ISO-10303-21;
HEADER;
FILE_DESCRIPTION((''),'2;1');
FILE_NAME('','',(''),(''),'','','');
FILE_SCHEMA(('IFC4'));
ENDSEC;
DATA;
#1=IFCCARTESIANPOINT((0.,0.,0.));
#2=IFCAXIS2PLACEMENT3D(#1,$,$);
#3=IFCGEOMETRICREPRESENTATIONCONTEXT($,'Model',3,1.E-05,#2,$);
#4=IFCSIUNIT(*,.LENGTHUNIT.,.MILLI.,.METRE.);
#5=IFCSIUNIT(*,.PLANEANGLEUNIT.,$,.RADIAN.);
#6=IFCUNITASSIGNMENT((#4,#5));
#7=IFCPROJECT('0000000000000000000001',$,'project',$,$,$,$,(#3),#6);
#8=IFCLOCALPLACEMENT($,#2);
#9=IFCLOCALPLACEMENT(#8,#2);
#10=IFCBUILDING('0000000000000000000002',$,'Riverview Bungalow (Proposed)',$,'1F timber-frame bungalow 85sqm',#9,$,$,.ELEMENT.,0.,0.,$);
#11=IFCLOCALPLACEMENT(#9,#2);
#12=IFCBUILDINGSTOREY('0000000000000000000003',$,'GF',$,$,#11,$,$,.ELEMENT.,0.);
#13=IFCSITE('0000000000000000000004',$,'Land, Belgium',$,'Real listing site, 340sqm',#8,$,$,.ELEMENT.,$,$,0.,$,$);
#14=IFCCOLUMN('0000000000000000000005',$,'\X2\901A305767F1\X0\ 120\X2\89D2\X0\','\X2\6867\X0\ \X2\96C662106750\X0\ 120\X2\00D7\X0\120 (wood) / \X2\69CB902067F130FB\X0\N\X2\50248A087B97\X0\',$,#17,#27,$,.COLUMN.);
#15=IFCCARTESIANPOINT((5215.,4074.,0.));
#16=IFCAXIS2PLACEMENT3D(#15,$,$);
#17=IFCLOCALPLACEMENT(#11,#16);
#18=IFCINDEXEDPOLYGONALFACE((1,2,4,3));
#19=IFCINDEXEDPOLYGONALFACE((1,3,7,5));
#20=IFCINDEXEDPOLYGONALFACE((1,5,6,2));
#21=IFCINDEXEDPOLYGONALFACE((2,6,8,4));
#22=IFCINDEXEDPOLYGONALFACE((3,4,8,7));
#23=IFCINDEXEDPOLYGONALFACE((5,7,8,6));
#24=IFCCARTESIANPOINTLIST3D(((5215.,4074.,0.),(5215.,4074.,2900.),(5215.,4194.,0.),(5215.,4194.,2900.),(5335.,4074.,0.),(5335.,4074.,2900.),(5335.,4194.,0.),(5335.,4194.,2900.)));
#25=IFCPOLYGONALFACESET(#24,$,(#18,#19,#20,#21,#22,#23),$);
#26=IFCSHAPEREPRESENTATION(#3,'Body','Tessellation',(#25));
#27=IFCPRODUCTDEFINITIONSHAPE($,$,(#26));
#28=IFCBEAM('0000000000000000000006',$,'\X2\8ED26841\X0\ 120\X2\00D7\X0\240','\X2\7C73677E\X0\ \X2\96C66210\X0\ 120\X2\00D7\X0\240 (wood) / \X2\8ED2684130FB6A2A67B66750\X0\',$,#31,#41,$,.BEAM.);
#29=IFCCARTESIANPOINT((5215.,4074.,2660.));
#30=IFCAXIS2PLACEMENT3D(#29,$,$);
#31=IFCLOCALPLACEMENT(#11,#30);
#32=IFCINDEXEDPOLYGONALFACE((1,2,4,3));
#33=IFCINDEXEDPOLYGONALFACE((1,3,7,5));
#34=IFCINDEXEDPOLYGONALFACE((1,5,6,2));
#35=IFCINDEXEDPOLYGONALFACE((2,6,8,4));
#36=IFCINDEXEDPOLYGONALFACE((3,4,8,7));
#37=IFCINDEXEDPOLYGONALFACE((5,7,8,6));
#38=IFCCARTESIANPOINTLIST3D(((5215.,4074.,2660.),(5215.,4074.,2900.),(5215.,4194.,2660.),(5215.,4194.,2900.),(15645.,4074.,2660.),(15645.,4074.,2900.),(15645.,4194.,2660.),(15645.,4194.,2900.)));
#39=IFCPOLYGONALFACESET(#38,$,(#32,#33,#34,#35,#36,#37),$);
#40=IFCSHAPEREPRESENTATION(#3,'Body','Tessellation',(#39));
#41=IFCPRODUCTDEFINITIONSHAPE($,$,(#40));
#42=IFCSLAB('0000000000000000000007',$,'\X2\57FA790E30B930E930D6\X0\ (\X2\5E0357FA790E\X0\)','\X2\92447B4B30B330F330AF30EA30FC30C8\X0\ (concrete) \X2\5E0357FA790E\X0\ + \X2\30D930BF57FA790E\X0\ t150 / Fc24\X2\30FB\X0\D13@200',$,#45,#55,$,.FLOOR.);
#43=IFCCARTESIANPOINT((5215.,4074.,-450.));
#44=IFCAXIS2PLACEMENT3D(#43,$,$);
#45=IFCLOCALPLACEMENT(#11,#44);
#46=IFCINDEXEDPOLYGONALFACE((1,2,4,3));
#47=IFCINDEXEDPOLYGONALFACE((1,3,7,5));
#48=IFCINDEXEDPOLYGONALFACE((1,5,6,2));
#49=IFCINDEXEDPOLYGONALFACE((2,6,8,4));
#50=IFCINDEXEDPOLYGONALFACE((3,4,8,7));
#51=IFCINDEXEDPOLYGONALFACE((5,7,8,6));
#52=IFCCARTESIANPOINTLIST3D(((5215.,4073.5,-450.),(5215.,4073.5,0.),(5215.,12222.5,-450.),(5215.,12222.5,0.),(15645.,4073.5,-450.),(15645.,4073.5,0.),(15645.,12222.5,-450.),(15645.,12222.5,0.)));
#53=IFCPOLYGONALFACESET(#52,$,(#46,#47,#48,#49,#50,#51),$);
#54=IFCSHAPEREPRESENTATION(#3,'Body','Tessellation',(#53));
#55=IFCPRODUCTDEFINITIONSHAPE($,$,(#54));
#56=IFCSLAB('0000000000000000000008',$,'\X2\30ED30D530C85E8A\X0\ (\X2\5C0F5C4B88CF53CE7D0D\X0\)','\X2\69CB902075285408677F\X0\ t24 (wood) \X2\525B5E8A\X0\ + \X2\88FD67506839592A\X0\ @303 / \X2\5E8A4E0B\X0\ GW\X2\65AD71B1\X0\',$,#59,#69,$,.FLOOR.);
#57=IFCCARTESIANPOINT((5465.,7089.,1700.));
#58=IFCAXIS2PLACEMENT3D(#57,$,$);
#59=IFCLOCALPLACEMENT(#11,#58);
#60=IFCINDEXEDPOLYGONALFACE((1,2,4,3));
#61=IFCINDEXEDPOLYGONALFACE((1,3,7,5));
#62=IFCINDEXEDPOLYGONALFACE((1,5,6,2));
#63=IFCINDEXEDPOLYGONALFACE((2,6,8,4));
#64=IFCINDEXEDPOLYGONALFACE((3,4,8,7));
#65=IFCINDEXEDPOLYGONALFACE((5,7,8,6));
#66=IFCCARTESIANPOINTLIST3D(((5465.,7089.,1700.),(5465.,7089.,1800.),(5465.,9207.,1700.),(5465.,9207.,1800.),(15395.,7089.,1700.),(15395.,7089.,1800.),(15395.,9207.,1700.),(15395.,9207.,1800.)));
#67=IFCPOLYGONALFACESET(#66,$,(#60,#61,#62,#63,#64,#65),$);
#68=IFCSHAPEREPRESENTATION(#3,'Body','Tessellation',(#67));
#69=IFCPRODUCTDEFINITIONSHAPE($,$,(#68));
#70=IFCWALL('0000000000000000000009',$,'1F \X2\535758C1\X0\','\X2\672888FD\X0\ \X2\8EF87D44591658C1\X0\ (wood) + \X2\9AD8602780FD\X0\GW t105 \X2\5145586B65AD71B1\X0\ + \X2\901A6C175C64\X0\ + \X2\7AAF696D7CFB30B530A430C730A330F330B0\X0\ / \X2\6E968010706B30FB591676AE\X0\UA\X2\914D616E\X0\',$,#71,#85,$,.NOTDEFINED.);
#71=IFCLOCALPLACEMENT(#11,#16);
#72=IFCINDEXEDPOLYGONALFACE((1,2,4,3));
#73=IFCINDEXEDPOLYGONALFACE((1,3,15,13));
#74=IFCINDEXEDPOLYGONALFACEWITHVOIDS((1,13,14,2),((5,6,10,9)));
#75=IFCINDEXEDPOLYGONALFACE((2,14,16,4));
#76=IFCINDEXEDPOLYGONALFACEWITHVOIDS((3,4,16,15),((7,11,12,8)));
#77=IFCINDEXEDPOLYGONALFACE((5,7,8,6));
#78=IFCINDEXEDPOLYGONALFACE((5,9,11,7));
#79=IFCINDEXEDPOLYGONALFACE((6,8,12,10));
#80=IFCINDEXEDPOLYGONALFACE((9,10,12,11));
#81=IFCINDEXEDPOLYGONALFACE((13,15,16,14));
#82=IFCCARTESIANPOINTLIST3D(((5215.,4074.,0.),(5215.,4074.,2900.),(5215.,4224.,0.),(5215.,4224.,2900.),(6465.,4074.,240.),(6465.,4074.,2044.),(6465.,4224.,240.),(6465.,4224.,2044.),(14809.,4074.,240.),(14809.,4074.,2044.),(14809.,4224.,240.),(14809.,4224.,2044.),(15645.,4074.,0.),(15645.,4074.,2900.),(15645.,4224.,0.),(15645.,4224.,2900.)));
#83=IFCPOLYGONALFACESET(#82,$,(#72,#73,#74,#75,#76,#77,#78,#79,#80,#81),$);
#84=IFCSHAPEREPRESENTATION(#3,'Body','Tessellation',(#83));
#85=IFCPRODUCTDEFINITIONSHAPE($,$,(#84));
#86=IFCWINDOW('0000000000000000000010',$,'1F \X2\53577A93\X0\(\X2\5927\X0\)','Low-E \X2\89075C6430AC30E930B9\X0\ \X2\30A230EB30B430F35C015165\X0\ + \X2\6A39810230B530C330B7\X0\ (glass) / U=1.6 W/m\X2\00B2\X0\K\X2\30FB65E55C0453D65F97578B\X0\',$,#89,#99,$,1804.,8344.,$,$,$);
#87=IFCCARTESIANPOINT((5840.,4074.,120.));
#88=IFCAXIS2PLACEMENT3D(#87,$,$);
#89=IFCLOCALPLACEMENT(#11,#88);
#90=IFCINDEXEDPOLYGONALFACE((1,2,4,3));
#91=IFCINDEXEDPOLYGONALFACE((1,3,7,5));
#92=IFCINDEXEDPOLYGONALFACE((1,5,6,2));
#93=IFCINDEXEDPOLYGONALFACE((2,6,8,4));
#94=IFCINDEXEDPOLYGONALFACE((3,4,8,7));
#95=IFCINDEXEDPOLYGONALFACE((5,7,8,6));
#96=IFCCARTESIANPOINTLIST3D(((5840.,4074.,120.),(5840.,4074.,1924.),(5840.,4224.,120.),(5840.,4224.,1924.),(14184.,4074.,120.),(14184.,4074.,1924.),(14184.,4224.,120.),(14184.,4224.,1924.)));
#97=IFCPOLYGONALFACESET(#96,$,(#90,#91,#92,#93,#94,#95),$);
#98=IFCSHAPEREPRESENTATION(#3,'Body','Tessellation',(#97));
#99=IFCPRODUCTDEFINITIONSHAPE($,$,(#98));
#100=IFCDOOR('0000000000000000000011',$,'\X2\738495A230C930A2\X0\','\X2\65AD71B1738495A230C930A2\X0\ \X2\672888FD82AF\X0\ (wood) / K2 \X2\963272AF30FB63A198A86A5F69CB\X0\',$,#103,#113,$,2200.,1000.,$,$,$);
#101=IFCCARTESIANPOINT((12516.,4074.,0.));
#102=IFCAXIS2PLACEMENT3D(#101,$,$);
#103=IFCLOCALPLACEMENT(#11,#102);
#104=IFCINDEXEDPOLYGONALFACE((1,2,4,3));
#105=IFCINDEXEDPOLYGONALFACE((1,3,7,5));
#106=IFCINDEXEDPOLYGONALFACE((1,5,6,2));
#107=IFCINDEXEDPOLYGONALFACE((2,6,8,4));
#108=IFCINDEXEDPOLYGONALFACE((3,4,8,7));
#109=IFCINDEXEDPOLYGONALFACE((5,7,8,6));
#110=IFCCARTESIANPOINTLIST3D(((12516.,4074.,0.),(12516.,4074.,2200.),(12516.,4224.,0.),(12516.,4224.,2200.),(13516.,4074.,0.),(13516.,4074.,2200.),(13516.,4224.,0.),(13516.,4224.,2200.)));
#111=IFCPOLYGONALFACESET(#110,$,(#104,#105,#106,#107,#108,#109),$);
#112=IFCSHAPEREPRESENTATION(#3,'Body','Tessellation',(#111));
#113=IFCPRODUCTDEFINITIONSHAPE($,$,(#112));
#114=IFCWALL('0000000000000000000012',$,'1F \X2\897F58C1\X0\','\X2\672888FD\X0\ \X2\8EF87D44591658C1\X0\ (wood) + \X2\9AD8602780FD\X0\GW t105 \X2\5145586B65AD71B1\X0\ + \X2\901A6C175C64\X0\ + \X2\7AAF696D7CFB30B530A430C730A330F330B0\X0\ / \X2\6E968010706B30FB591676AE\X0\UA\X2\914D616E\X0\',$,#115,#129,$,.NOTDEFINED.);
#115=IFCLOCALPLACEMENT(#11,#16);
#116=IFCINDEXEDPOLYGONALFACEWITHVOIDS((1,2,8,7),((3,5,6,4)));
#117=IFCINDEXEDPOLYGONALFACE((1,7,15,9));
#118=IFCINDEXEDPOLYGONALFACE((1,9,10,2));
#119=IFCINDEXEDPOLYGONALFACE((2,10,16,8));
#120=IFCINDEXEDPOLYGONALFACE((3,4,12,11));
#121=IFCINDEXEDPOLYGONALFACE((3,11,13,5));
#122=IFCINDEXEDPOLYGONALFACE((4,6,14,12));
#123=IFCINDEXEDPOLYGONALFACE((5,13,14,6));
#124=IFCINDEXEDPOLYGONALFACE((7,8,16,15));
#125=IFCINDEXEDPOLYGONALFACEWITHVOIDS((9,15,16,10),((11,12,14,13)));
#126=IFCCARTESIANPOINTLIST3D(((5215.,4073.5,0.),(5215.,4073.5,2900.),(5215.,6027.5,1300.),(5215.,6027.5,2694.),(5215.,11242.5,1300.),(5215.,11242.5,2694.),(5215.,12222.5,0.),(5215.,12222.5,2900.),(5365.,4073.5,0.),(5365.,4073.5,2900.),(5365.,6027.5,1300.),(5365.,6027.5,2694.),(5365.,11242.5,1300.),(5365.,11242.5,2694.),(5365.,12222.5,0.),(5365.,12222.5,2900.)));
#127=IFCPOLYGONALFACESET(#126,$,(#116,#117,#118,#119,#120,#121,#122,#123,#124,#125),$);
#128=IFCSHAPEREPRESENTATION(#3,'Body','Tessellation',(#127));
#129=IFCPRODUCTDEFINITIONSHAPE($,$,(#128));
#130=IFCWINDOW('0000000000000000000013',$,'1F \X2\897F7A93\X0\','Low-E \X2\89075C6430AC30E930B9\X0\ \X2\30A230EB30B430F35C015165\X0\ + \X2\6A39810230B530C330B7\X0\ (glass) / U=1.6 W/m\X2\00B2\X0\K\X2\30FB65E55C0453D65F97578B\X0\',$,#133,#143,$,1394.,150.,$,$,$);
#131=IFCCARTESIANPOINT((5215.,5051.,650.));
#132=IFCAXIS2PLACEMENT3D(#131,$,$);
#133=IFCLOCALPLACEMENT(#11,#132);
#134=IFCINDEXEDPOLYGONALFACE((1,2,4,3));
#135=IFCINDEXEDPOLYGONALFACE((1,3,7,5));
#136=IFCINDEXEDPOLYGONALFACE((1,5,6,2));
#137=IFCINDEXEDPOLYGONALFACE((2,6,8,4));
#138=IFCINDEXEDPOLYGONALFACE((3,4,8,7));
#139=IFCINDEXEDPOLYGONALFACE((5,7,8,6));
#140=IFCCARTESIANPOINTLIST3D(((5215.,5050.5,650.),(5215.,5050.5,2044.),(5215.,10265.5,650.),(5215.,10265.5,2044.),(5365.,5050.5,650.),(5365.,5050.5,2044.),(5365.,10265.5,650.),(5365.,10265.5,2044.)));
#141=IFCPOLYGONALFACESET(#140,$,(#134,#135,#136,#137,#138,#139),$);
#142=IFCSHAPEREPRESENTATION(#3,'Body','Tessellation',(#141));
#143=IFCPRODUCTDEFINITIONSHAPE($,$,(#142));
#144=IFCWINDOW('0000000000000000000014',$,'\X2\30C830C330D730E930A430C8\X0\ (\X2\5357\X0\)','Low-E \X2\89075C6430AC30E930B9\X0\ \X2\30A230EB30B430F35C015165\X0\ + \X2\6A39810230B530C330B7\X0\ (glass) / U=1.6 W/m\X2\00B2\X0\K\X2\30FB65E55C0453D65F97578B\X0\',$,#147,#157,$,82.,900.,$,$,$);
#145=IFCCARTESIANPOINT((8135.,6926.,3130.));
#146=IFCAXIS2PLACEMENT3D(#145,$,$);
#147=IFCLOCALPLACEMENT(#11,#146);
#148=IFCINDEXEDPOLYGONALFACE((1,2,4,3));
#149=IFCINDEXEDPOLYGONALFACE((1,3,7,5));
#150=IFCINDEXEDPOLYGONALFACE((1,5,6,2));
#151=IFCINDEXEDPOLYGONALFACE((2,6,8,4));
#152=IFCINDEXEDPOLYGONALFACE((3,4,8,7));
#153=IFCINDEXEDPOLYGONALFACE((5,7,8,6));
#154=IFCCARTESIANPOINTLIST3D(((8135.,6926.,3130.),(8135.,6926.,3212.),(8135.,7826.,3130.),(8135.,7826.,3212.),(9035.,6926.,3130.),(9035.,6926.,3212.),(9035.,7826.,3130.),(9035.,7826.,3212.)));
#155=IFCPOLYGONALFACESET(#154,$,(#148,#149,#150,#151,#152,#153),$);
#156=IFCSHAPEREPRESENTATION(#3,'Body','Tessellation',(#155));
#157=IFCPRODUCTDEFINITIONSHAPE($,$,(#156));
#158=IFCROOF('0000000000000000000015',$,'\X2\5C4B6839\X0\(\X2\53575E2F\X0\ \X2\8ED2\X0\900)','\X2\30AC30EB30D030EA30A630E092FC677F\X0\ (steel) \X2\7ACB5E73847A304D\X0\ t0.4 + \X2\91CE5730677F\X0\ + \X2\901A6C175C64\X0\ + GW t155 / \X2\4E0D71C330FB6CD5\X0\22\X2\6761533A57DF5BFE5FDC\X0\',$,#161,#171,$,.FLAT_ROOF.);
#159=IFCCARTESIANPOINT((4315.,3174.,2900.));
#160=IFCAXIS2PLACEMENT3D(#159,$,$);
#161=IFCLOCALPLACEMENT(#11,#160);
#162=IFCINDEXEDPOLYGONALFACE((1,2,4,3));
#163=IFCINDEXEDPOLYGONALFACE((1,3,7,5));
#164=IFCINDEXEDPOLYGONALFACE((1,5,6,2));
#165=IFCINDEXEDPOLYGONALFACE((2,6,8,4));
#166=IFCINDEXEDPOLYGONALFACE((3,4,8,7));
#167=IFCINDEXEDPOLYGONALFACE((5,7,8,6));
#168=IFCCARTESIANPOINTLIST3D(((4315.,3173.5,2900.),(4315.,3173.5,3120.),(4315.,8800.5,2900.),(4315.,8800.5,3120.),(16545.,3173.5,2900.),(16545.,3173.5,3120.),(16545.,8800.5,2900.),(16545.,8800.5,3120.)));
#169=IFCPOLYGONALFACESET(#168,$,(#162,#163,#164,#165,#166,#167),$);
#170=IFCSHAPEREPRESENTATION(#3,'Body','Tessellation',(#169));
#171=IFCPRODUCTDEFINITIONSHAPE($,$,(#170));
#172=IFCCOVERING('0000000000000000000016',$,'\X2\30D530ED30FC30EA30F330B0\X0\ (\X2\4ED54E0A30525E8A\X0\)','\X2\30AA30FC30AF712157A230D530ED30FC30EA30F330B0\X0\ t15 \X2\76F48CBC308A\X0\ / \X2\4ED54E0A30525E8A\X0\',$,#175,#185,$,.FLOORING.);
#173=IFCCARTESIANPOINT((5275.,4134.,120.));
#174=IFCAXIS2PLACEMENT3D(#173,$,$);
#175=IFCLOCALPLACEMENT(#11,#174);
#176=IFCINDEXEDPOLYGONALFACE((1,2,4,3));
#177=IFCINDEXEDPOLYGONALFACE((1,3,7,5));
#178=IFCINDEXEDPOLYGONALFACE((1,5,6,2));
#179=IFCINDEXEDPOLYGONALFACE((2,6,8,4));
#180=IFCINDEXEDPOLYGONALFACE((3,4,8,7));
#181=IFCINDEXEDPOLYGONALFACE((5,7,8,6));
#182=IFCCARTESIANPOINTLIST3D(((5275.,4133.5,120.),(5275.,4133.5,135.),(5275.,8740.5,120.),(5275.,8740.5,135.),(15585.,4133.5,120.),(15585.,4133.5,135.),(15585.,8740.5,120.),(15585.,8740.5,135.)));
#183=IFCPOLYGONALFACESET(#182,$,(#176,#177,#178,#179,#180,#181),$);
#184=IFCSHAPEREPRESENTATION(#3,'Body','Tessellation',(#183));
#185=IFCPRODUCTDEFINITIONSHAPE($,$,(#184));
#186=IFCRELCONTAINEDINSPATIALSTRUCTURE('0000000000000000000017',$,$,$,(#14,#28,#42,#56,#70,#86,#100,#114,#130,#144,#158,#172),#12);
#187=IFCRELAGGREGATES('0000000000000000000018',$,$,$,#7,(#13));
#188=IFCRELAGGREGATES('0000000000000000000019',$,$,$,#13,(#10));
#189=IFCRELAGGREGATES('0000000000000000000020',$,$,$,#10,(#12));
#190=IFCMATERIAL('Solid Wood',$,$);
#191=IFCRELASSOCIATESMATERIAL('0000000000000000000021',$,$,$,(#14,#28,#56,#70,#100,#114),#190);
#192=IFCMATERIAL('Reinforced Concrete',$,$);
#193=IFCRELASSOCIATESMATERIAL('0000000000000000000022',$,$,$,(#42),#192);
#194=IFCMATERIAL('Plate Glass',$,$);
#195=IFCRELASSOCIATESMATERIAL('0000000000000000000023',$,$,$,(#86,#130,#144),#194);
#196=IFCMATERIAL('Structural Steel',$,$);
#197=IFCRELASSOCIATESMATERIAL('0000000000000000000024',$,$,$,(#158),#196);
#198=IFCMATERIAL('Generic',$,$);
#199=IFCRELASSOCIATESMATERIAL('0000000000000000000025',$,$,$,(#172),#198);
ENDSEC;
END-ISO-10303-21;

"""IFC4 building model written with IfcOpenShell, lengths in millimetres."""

from ifc_helpers import new_model, si_unit, frame, frame_2d, origin, place, context, project, spatial, rectangle, extrude, material, element, fill, save


model = new_model("IFC4")

# Units and contexts
model_context = context("Model", 3, precision=1e-05, world=origin())
ifc_project = project(units=[si_unit("LENGTHUNIT", "METRE", prefix="MILLI"), si_unit("PLANEANGLEUNIT", "RADIAN")], contexts=[model_context])

# Site, building, storey
site_placement = place(None, origin())
site = spatial("IfcSite", under=ifc_project, at=site_placement, Name="Land, Belgium", ObjectType="Real listing site, 340sqm", CompositionType="ELEMENT", RefElevation=0.0)
building_placement = place(site_placement, origin())
building = spatial("IfcBuilding", under=site, at=building_placement, Name="Riverview Bungalow (Proposed)", ObjectType="1F timber-frame bungalow 85sqm", CompositionType="ELEMENT", ElevationOfRefHeight=0.0, ElevationOfTerrain=0.0)
storey_placement = place(building_placement, origin())
storey = spatial("IfcBuildingStorey", under=building, at=storey_placement, Name="GF", CompositionType="ELEMENT", Elevation=0.0)

# Column
ifc_material_1 = material(Name="Solid Wood")
column_1_placement = place(storey_placement, frame((5215.0, 4074.0, 0.0)))
element("IfcColumn", 1, at=column_1_placement, inside=storey, material=ifc_material_1, Name="通し柱 120角", Description="桧 集成材 120×120 (wood) / 構造柱・N値計算", PredefinedType="COLUMN", context=model_context, shape_type="SweptSolid", body=[
    extrude(rectangle(XDim=120.0, YDim=120.0, at=frame_2d((60.0, 60.0))), frame((5215.0, 4074.0, 0.0)), (0.0, 0.0, 1.0), 2900.0),
])

# Beam
beam_1_placement = place(storey_placement, frame((5215.0, 4074.0, 2660.0)))
element("IfcBeam", 2, at=beam_1_placement, inside=storey, material=ifc_material_1, Name="軒桁 120×240", Description="米松 集成 120×240 (wood) / 軒桁・横架材", PredefinedType="BEAM", context=model_context, shape_type="SweptSolid", body=[
    extrude(rectangle(XDim=10430.0, YDim=120.0, at=frame_2d((5215.0, 60.0))), frame((5215.0, 4074.0, 2660.0)), (0.0, 0.0, 1.0), 240.0),
])

# Slabs
ifc_material_2 = material(Name="Reinforced Concrete")
slab_1_placement = place(storey_placement, frame((5215.0, 4074.0, -450.0)))
element("IfcSlab", 3, at=slab_1_placement, inside=storey, material=ifc_material_2, Name="基礎スラブ (布基礎)", Description="鉄筋コンクリート (concrete) 布基礎 + ベタ基礎 t150 / Fc24・D13@200", PredefinedType="FLOOR", context=model_context, shape_type="SweptSolid", body=[
    extrude(rectangle(XDim=10430.0, YDim=8149.0, at=frame_2d((5215.0, 4074.0))), frame((5215.0, 4074.0, -450.0)), (0.0, 0.0, 1.0), 450.0),
])
slab_2_placement = place(storey_placement, frame((5465.0, 7089.0, 1700.0)))
element("IfcSlab", 4, at=slab_2_placement, inside=storey, material=ifc_material_1, Name="ロフト床 (小屋裏収納)", Description="構造用合板 t24 (wood) 剛床 + 製材根太 @303 / 床下 GW断熱", PredefinedType="FLOOR", context=model_context, shape_type="SweptSolid", body=[
    extrude(rectangle(XDim=9930.0, YDim=2118.0, at=frame_2d((4965.0, 1059.0))), frame((5465.0, 7089.0, 1700.0)), (0.0, 0.0, 1.0), 100.0),
])

# Wall, openings, window, door
wall_1_placement = place(storey_placement, frame((5215.0, 4074.0, 0.0)))
wall_1 = element("IfcWall", 5, at=wall_1_placement, inside=storey, material=ifc_material_1, Name="1F 南壁", Description="木製 軸組外壁 (wood) + 高性能GW t105 充填断熱 + 通気層 + 窯業系サイディング / 準耐火・外皮UA配慮", PredefinedType="NOTDEFINED", context=model_context, shape_type="SweptSolid", body=[
    extrude(rectangle(XDim=10430.0, YDim=150.0, at=frame_2d((5215.0, 75.0))), frame((5215.0, 4074.0, 0.0)), (0.0, 0.0, 1.0), 2900.0),
])
opening_1_placement = place(storey_placement, frame((5840.0, 4074.0, 120.0)))
opening_1 = element("IfcOpeningElement", 6, at=opening_1_placement, cuts=wall_1, PredefinedType="NOTDEFINED", context=model_context, shape_type="SweptSolid", body=[
    extrude(rectangle(XDim=8344.0, YDim=150.0, at=frame_2d((4172.0, 75.0))), frame((5840.0, 4074.0, 120.0)), (0.0, 0.0, 1.0), 1804.0),
])
opening_2_placement = place(storey_placement, frame((12516.0, 4074.0, 0.0)))
opening_2 = element("IfcOpeningElement", 7, at=opening_2_placement, cuts=wall_1, PredefinedType="NOTDEFINED", context=model_context, shape_type="SweptSolid", body=[
    extrude(rectangle(XDim=1000.0, YDim=150.0, at=frame_2d((500.0, 75.0))), frame((12516.0, 4074.0, 0.0)), (0.0, 0.0, 1.0), 2200.0),
])
ifc_material_3 = material(Name="Plate Glass")
window_1_placement = place(storey_placement, frame((5840.0, 4074.0, 120.0)))
window_1 = element("IfcWindow", 8, at=window_1_placement, inside=storey, material=ifc_material_3, Name="1F 南窓(大)", Description="Low-E 複層ガラス アルゴン封入 + 樹脂サッシ (glass) / U=1.6 W/m²K・日射取得型", OverallHeight=1804.0, OverallWidth=8344.0, context=model_context, shape_type="SweptSolid", body=[
    extrude(rectangle(XDim=8344.0, YDim=150.0, at=frame_2d((4172.0, 75.0))), frame((5840.0, 4074.0, 120.0)), (0.0, 0.0, 1.0), 1804.0),
])
fill(opening_1, window_1)
door_placement = place(storey_placement, frame((12516.0, 4074.0, 0.0)))
door = element("IfcDoor", 9, at=door_placement, inside=storey, material=ifc_material_1, Name="玄関ドア", Description="断熱玄関ドア 木製芯 (wood) / K2 防犯・採風機構", OverallHeight=2200.0, OverallWidth=1000.0, context=model_context, shape_type="SweptSolid", body=[
    extrude(rectangle(XDim=1000.0, YDim=150.0, at=frame_2d((500.0, 75.0))), frame((12516.0, 4074.0, 0.0)), (0.0, 0.0, 1.0), 2200.0),
])
fill(opening_2, door)

# Wall, opening, window
wall_2_placement = place(storey_placement, frame((5215.0, 4074.0, 0.0)))
wall_2 = element("IfcWall", 10, at=wall_2_placement, inside=storey, material=ifc_material_1, Name="1F 西壁", Description="木製 軸組外壁 (wood) + 高性能GW t105 充填断熱 + 通気層 + 窯業系サイディング / 準耐火・外皮UA配慮", PredefinedType="NOTDEFINED", context=model_context, shape_type="SweptSolid", body=[
    extrude(rectangle(XDim=150.0, YDim=8149.0, at=frame_2d((75.0, 4074.0))), frame((5215.0, 4074.0, 0.0)), (0.0, 0.0, 1.0), 2900.0),
])
opening_3_placement = place(storey_placement, frame((5215.0, 5051.0, 650.0)))
opening_3 = element("IfcOpeningElement", 11, at=opening_3_placement, cuts=wall_2, PredefinedType="NOTDEFINED", context=model_context, shape_type="SweptSolid", body=[
    extrude(rectangle(XDim=150.0, YDim=5215.0, at=frame_2d((75.0, 2607.0))), frame((5215.0, 5051.0, 650.0)), (0.0, 0.0, 1.0), 1394.0),
])
window_2_placement = place(storey_placement, frame((5215.0, 5051.0, 650.0)))
window_2 = element("IfcWindow", 12, at=window_2_placement, inside=storey, material=ifc_material_3, Name="1F 西窓", Description="Low-E 複層ガラス アルゴン封入 + 樹脂サッシ (glass) / U=1.6 W/m²K・日射取得型", OverallHeight=1394.0, OverallWidth=150.0, context=model_context, shape_type="SweptSolid", body=[
    extrude(rectangle(XDim=150.0, YDim=5215.0, at=frame_2d((75.0, 2607.0))), frame((5215.0, 5051.0, 650.0)), (0.0, 0.0, 1.0), 1394.0),
])
fill(opening_3, window_2)

# Window
window_3_placement = place(storey_placement, frame((8135.0, 6926.0, 3130.0)))
element("IfcWindow", 13, at=window_3_placement, inside=storey, material=ifc_material_3, Name="トップライト (南)", Description="Low-E 複層ガラス アルゴン封入 + 樹脂サッシ (glass) / U=1.6 W/m²K・日射取得型", OverallHeight=82.0, OverallWidth=900.0, context=model_context, shape_type="SweptSolid", body=[
    extrude(rectangle(XDim=900.0, YDim=900.0, at=frame_2d((450.0, 450.0))), frame((8135.0, 6926.0, 3130.0)), (0.0, 0.0, 1.0), 82.0),
])

# Roof
ifc_material_4 = material(Name="Structural Steel")
roof_placement = place(storey_placement, frame((4315.0, 3174.0, 2900.0)))
element("IfcRoof", 14, at=roof_placement, inside=storey, material=ifc_material_4, Name="屋根(南帯 軒900)", Description="ガルバリウム鋼板 (steel) 立平葺き t0.4 + 野地板 + 通気層 + GW t155 / 不燃・法22条区域対応", PredefinedType="FLAT_ROOF", context=model_context, shape_type="SweptSolid", body=[
    extrude(rectangle(XDim=12230.0, YDim=5627.0, at=frame_2d((6115.0, 2813.0))), frame((4315.0, 3174.0, 2900.0)), (0.0, 0.0, 1.0), 220.0),
])

# Covering
ifc_material_5 = material(Name="Generic")
covering_1_placement = place(storey_placement, frame((5275.0, 4134.0, 120.0)))
element("IfcCovering", 15, at=covering_1_placement, inside=storey, material=ifc_material_5, Name="フローリング (仕上げ床)", Description="オーク無垢フローリング t15 直貼り / 仕上げ床", PredefinedType="FLOORING", context=model_context, shape_type="SweptSolid", body=[
    extrude(rectangle(XDim=10310.0, YDim=4607.0, at=frame_2d((5155.0, 2303.0))), frame((5275.0, 4134.0, 120.0)), (0.0, 0.0, 1.0), 15.0),
])

save(model, "model.ifc")
